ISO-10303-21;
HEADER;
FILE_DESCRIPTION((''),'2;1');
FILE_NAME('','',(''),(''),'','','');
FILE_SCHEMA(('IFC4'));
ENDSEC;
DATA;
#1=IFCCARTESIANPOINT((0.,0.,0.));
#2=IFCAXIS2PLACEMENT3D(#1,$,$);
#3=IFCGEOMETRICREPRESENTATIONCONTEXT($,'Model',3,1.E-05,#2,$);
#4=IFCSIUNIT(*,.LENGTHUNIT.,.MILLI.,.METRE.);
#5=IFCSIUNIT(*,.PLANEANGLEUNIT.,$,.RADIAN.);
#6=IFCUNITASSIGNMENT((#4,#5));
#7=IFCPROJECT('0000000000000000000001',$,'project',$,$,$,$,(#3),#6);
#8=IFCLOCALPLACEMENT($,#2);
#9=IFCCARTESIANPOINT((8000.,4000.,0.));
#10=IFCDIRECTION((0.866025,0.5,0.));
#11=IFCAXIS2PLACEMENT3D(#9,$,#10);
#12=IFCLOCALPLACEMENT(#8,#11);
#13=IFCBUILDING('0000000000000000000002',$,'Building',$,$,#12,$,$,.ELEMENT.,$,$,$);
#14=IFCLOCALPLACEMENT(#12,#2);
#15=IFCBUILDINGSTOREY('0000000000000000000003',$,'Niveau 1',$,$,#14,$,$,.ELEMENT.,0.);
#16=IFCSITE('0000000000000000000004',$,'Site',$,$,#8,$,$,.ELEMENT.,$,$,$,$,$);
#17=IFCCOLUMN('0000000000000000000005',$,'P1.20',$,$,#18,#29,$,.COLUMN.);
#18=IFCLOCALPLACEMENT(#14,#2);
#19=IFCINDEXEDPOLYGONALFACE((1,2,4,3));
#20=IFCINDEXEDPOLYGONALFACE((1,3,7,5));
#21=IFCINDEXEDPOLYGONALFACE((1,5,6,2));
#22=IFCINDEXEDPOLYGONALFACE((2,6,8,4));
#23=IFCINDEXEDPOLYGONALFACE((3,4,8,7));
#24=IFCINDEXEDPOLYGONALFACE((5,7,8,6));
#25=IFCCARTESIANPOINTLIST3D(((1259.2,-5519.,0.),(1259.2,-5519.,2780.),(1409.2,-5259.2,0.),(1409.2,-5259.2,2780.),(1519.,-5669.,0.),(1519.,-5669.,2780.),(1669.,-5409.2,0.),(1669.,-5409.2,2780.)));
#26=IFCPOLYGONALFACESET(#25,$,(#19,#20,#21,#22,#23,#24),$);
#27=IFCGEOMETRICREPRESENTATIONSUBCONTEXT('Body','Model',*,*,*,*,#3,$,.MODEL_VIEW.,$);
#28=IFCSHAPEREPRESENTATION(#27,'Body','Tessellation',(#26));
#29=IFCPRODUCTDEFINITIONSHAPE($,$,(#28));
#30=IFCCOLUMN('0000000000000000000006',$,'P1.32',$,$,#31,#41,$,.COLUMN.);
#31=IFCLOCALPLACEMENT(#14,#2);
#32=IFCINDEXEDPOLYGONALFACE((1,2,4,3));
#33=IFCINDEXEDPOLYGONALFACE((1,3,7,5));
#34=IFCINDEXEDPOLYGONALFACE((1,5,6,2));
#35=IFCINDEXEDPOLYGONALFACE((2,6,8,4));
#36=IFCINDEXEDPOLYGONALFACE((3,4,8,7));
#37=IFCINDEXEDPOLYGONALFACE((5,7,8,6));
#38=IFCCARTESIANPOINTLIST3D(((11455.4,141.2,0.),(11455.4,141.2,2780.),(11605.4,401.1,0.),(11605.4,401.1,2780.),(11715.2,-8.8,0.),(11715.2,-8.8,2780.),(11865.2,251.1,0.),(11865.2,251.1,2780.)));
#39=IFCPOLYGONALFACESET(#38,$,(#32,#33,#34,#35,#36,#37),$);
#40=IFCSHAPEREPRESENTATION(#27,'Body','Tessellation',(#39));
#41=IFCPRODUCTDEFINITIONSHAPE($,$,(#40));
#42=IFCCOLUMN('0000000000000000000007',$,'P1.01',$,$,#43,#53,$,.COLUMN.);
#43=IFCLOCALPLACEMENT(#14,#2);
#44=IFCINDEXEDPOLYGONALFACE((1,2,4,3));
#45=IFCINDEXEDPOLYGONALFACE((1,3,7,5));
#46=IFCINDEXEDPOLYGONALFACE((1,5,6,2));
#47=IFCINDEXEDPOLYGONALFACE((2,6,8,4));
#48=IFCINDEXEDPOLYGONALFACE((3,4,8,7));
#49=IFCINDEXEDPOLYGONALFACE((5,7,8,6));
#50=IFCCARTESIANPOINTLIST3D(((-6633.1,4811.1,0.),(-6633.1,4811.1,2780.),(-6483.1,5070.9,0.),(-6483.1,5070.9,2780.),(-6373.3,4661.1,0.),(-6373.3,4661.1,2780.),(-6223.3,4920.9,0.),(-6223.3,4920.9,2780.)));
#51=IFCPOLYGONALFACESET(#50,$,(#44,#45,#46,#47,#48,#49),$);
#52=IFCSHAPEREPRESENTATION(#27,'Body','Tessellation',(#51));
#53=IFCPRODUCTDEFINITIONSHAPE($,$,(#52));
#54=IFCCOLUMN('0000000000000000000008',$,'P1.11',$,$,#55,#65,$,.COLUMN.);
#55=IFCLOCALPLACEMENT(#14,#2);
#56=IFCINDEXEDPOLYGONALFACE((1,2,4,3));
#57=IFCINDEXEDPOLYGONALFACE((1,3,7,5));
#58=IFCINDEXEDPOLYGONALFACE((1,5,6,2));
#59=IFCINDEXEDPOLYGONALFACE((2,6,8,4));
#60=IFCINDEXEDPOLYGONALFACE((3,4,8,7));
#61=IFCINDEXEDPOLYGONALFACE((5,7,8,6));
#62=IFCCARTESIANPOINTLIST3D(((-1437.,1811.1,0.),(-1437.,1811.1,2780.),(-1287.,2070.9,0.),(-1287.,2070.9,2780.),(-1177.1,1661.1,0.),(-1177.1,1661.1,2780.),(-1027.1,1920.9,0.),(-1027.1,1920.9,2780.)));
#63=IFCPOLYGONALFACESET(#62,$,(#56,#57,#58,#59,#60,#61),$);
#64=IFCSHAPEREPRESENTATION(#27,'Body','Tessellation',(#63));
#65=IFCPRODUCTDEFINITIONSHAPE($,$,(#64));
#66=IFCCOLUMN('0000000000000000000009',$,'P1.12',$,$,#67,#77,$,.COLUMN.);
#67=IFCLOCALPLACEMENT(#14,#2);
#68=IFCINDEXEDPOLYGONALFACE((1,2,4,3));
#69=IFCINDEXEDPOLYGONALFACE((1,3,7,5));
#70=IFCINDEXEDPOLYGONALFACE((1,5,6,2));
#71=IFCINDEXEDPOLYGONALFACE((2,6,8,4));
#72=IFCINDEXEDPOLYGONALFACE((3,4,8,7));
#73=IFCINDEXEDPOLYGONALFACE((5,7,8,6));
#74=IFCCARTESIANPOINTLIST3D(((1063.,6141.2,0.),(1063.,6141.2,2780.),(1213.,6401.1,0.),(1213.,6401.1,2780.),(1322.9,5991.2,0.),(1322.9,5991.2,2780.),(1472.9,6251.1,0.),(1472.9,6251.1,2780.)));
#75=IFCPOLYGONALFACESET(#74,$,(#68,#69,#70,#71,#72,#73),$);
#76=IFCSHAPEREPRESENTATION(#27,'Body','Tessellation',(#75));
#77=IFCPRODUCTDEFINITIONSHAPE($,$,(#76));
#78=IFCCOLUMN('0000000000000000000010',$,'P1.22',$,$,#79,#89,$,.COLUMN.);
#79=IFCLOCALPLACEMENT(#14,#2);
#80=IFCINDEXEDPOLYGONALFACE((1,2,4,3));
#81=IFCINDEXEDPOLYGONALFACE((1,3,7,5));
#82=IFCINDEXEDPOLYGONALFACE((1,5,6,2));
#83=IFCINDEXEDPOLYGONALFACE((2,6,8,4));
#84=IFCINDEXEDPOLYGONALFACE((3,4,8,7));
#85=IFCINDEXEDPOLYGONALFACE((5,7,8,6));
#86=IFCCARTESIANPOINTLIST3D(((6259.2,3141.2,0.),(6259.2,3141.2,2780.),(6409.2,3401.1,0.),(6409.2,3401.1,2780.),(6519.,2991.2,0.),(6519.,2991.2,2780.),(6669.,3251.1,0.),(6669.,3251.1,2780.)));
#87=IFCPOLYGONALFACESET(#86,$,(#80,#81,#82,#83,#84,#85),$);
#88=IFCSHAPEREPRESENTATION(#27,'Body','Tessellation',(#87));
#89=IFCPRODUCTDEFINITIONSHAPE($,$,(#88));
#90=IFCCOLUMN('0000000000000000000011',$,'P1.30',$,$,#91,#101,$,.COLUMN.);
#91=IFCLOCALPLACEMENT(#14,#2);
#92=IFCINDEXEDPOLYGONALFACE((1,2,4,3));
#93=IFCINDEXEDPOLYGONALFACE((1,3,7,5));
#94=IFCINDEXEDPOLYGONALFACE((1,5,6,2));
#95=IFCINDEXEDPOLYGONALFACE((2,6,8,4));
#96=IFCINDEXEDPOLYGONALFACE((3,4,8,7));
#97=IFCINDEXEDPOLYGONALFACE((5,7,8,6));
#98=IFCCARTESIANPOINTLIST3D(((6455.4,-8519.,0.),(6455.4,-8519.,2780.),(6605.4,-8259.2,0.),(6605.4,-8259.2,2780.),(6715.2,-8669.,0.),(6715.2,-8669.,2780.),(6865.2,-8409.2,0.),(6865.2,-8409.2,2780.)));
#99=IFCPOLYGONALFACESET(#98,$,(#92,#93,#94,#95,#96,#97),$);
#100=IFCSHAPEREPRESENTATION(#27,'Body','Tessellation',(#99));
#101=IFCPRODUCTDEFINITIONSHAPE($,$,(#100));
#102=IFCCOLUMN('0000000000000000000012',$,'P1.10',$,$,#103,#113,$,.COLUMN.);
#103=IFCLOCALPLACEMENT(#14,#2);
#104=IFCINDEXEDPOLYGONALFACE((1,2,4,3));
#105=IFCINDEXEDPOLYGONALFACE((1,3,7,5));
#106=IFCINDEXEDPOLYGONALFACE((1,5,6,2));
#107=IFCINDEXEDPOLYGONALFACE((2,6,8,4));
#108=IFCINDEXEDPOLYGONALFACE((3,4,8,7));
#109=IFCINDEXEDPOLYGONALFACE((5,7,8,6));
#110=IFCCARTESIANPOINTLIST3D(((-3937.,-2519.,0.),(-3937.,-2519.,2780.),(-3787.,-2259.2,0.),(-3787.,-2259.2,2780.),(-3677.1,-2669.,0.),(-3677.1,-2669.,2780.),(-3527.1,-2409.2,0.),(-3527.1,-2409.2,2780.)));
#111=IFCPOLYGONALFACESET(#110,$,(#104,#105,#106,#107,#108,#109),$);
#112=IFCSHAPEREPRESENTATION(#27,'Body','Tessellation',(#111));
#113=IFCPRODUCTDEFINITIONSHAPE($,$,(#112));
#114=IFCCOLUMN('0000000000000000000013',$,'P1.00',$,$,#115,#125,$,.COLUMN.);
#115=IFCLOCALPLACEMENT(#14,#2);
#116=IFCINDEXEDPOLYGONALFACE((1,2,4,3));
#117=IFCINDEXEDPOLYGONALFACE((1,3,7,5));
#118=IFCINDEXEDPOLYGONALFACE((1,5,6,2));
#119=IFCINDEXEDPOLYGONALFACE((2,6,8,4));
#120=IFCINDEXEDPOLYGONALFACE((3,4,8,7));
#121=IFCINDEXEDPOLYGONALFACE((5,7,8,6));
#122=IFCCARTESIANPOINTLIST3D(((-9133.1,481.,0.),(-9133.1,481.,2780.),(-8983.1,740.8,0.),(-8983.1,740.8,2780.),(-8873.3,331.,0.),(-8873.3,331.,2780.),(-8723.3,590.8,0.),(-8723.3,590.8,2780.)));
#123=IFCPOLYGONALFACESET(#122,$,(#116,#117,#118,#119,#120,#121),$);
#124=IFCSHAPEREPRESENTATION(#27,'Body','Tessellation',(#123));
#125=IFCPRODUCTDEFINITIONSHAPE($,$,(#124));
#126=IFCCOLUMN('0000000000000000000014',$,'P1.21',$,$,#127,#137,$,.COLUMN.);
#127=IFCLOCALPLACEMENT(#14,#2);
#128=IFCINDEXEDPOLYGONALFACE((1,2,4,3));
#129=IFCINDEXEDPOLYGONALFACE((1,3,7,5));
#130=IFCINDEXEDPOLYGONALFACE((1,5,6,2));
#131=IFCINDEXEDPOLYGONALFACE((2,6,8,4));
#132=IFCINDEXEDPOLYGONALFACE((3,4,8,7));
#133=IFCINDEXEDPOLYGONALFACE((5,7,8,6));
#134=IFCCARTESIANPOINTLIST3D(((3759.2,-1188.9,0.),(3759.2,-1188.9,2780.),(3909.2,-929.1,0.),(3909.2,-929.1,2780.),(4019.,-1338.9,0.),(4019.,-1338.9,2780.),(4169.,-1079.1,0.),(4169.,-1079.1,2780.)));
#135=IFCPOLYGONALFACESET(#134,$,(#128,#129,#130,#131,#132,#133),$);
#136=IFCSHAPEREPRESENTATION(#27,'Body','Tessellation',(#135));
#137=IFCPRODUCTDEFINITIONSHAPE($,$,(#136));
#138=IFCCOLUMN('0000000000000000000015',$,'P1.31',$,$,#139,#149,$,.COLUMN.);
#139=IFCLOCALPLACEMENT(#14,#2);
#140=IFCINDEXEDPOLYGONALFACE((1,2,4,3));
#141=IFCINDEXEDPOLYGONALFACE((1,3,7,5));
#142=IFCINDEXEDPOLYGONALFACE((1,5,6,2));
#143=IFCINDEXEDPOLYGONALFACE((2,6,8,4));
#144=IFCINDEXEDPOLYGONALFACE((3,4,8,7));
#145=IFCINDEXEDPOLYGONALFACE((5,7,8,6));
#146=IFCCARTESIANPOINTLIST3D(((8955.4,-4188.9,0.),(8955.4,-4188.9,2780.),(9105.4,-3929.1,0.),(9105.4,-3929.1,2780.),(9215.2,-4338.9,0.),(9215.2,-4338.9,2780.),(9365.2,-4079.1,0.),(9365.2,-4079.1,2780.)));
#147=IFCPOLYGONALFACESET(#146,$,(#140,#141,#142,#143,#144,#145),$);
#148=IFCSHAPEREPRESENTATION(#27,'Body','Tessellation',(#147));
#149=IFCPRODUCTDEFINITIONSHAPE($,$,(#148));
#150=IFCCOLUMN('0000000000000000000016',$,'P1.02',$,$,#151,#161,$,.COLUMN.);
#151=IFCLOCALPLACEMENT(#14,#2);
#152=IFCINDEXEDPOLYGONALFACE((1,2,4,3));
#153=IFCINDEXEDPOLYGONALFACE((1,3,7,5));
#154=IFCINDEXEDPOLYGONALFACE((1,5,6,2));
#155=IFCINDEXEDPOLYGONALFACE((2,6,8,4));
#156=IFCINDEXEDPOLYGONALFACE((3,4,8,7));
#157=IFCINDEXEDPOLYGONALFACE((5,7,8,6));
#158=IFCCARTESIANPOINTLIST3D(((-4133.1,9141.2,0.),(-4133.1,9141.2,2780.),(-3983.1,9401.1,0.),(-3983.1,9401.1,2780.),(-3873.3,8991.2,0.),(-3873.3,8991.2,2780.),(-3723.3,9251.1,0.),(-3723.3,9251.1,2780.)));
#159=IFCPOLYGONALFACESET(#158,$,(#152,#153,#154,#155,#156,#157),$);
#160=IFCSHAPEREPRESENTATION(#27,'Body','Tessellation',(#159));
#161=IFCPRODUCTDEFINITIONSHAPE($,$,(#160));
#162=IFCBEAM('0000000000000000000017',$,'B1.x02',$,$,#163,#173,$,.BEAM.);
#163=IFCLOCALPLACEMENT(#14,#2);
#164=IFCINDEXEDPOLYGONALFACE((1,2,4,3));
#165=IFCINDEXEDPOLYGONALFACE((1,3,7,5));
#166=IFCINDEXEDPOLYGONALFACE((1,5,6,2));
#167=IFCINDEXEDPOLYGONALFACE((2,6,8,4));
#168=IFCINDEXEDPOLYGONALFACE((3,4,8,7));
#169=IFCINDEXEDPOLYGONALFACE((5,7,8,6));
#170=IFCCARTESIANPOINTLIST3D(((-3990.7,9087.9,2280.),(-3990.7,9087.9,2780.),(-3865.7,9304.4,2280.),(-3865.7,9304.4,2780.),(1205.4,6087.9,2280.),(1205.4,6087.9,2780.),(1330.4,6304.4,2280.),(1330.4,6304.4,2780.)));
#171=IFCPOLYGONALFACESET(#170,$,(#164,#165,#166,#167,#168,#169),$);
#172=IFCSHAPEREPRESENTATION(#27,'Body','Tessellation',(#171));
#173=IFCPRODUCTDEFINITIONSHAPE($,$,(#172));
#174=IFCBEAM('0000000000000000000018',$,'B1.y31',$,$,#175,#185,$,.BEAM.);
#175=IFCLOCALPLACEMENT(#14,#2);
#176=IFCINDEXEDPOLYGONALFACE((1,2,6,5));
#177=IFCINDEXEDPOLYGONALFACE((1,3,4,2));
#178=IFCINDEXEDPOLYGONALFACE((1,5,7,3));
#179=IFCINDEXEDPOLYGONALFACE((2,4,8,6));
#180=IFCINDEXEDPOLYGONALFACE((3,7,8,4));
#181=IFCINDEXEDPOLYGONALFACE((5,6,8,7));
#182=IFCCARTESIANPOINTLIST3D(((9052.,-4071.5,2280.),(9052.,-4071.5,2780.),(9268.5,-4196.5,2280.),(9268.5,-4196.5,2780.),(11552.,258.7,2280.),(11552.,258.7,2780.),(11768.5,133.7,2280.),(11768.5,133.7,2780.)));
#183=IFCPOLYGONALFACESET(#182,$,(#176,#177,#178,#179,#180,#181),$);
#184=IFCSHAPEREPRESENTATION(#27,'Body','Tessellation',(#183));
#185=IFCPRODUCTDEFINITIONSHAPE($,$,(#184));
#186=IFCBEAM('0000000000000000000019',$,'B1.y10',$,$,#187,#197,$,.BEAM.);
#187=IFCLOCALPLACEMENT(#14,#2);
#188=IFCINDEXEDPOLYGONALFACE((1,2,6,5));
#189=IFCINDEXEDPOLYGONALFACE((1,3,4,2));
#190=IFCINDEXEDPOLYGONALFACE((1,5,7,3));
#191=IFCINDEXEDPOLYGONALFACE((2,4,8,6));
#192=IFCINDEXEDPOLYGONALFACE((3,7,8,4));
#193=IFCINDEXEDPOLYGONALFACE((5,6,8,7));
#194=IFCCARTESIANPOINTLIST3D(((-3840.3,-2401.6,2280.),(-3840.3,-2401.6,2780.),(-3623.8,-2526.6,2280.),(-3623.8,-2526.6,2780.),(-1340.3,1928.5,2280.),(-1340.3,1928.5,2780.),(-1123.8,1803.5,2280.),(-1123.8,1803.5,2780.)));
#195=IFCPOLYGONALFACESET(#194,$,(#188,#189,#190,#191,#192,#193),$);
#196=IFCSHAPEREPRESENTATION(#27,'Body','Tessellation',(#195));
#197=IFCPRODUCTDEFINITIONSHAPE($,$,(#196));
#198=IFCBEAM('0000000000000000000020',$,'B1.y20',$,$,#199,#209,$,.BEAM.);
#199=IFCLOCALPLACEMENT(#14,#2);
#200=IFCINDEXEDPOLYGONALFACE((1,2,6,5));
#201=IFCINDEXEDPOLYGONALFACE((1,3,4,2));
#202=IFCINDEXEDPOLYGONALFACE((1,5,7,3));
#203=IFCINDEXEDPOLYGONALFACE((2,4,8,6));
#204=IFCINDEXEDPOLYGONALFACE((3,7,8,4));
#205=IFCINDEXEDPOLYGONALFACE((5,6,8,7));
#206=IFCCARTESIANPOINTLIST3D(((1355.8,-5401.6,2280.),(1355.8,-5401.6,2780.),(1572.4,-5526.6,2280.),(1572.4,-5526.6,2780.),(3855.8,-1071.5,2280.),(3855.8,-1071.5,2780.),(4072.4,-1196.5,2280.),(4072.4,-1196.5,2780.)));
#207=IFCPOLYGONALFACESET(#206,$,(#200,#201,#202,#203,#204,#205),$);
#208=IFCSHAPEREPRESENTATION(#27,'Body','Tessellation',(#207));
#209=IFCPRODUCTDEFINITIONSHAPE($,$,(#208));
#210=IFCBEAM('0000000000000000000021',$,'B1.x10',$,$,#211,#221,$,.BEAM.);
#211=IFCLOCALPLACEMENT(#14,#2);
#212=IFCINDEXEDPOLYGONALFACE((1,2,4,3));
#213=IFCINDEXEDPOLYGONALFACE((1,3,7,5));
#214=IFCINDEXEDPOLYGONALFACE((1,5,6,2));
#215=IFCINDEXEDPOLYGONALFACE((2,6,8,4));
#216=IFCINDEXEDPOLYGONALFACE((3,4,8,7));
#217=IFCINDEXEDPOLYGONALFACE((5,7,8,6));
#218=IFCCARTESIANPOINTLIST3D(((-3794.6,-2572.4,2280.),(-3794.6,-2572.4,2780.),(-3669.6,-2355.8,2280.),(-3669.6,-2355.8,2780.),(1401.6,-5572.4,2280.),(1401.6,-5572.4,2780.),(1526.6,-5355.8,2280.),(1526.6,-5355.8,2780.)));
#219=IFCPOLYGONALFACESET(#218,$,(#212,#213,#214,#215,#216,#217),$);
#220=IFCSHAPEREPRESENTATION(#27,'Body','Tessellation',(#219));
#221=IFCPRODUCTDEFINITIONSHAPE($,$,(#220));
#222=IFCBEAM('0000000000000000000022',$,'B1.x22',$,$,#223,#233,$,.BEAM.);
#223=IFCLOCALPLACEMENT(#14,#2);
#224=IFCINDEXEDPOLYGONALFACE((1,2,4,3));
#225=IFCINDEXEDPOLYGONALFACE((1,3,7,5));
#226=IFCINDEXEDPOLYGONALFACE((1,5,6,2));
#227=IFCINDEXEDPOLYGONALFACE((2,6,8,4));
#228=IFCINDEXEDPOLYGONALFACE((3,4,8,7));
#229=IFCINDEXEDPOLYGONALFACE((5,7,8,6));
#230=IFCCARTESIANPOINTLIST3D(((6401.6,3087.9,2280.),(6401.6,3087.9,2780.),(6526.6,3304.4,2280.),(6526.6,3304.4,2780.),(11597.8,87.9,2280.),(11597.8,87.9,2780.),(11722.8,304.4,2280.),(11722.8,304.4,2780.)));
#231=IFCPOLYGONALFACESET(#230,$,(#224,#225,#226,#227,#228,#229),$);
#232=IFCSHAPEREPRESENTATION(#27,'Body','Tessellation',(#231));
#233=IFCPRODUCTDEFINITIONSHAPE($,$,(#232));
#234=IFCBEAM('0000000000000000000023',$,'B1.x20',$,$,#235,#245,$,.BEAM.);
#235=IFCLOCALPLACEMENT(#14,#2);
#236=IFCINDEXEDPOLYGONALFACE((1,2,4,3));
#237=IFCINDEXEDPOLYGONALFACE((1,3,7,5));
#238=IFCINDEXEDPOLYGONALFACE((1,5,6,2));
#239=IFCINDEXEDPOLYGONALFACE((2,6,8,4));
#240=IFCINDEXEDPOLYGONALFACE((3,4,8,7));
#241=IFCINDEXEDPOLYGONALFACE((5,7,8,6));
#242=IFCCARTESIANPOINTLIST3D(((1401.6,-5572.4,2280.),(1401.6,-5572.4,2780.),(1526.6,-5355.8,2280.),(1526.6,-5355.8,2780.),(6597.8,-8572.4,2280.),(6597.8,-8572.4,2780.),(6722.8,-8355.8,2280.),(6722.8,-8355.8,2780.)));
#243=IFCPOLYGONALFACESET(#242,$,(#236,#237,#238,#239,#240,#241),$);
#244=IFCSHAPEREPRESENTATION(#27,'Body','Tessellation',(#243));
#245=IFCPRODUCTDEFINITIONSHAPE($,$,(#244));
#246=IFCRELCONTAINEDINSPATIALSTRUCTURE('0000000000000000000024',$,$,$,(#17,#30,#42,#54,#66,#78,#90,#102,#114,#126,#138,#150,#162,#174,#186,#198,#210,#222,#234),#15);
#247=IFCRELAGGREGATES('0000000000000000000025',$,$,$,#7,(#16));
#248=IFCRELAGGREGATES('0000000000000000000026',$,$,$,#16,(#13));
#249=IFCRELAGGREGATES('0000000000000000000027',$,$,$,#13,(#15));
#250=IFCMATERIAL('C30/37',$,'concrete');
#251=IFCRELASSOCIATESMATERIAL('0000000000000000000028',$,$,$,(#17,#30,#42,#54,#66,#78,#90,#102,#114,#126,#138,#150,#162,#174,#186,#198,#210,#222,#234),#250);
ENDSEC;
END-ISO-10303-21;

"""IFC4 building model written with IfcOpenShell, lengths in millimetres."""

from ifc_helpers import new_model, si_unit, frame, origin, place, context, subcontext, project, spatial, rectangle, extrude, material, element, save


model = new_model("IFC4")

# Units and contexts
model_context = context("Model", 3, precision=1e-05, world=origin())
body_context = subcontext(model_context, "Body", "Model", "MODEL_VIEW")
ifc_project = project(units=[si_unit("LENGTHUNIT", "METRE", prefix="MILLI"), si_unit("PLANEANGLEUNIT", "RADIAN")], contexts=[model_context])

# Site, building, storey
site_placement = place(None, origin())
site = spatial("IfcSite", under=ifc_project, at=site_placement, Name="Site", CompositionType="ELEMENT")
building_placement = place(site_placement, frame((8000.0, 4000.0, 0.0), x_axis=(0.866025, 0.5, 0.0)))
building = spatial("IfcBuilding", under=site, at=building_placement, Name="Building", CompositionType="ELEMENT")
storey_placement = place(building_placement, origin())
storey = spatial("IfcBuildingStorey", under=building, at=storey_placement, Name="Niveau 1", CompositionType="ELEMENT", Elevation=0.0)

# Columns
ifc_material = material(Name="C30/37", Category="concrete")
for number, where, z_axis, x_axis, name in (
    (1, (1464.1, -5464.1, 0.0), (0.0, 0.0, 1.0), (0.866025, -0.5, 0.0), "P1.20"),
    (2, (11660.3, 196.2, 0.0), (0.0, 0.0, 1.0), (0.866025, -0.5, 0.0), "P1.32"),
    (3, (-6428.2, 4866.0, 0.0), (0.0, 0.0, 1.0), (0.866025, -0.5, 0.0), "P1.01"),
    (4, (-1232.1, 1866.0, 0.0), (0.0, 0.0, 1.0), (0.866025, -0.5, 0.0), "P1.11"),
    (5, (1267.9, 6196.2, 0.0), (0.0, 0.0, 1.0), (0.866025, -0.5, 0.0), "P1.12"),
    (6, (6464.1, 3196.2, 0.0), (0.0, 0.0, 1.0), (0.866025, -0.5, 0.0), "P1.22"),
    (7, (6660.3, -8464.1, 0.0), (0.0, 0.0, 1.0), (0.866025, -0.5, 0.0), "P1.30"),
    (8, (-3732.1, -2464.1, 0.0), (0.0, 0.0, 1.0), (0.866025, -0.5, 0.0), "P1.10"),
    (9, (-8928.2, 535.9, 0.0), (0.0, 0.0, 1.0), (0.866025, -0.5, 0.0), "P1.00"),
    (10, (3964.1, -1134.0, 0.0), (0.0, 0.0, 1.0), (0.866025, -0.5, 0.0), "P1.21"),
    (11, (9160.3, -4134.0, 0.0), (0.0, 0.0, 1.0), (0.866025, -0.5, 0.0), "P1.31"),
    (12, (-3928.2, 9196.2, 0.0), (0.0, 0.0, 1.0), (0.866025, -0.5, 0.0), "P1.02"),
):
    element("IfcColumn", number, at=place(storey_placement, frame(where, z_axis=z_axis, x_axis=x_axis)), inside=storey, material=ifc_material, Name=name, PredefinedType="COLUMN", context=body_context, shape_type="SweptSolid", body=[
        extrude(rectangle(XDim=300.0, YDim=300.0), origin(), (0.0, 0.0, 1.0), 2780.0),
    ])

# Beams
beam_1_placement = place(storey_placement, frame((-3928.2, 9196.2, 2530.0), z_axis=(0.866025, -0.5, 0.0), x_axis=(0.5, 0.866025, 0.0)))
element("IfcBeam", 13, at=beam_1_placement, inside=storey, material=ifc_material, Name="B1.x02", PredefinedType="BEAM", context=body_context, shape_type="SweptSolid", body=[
    extrude(rectangle(XDim=250.0, YDim=500.0), origin(), (0.0, 0.0, 1.0), 6000.0),
])
for number, where, z_axis, x_axis, name in (
    (14, (9160.3, -4134.0, 2530.0), (0.5, 0.866025, 0.0), (-0.866025, 0.5, 0.0), "B1.y31"),
    (15, (-3732.1, -2464.1, 2530.0), (0.5, 0.866025, 0.0), (-0.866025, 0.5, 0.0), "B1.y10"),
    (16, (1464.1, -5464.1, 2530.0), (0.5, 0.866025, 0.0), (-0.866025, 0.5, 0.0), "B1.y20"),
):
    element("IfcBeam", number, at=place(storey_placement, frame(where, z_axis=z_axis, x_axis=x_axis)), inside=storey, material=ifc_material, Name=name, PredefinedType="BEAM", context=body_context, shape_type="SweptSolid", body=[
        extrude(rectangle(XDim=250.0, YDim=500.0), origin(), (0.0, 0.0, 1.0), 5000.0),
    ])
for number, where, z_axis, x_axis, name in (
    (17, (-3732.1, -2464.1, 2530.0), (0.866025, -0.5, 0.0), (0.5, 0.866025, 0.0), "B1.x10"),
    (18, (6464.1, 3196.2, 2530.0), (0.866025, -0.5, 0.0), (0.5, 0.866025, 0.0), "B1.x22"),
    (19, (1464.1, -5464.1, 2530.0), (0.866025, -0.5, 0.0), (0.5, 0.866025, 0.0), "B1.x20"),
):
    element("IfcBeam", number, at=place(storey_placement, frame(where, z_axis=z_axis, x_axis=x_axis)), inside=storey, material=ifc_material, Name=name, PredefinedType="BEAM", context=body_context, shape_type="SweptSolid", body=[
        extrude(rectangle(XDim=250.0, YDim=500.0), origin(), (0.0, 0.0, 1.0), 6000.0),
    ])

save(model, "model.ifc")
